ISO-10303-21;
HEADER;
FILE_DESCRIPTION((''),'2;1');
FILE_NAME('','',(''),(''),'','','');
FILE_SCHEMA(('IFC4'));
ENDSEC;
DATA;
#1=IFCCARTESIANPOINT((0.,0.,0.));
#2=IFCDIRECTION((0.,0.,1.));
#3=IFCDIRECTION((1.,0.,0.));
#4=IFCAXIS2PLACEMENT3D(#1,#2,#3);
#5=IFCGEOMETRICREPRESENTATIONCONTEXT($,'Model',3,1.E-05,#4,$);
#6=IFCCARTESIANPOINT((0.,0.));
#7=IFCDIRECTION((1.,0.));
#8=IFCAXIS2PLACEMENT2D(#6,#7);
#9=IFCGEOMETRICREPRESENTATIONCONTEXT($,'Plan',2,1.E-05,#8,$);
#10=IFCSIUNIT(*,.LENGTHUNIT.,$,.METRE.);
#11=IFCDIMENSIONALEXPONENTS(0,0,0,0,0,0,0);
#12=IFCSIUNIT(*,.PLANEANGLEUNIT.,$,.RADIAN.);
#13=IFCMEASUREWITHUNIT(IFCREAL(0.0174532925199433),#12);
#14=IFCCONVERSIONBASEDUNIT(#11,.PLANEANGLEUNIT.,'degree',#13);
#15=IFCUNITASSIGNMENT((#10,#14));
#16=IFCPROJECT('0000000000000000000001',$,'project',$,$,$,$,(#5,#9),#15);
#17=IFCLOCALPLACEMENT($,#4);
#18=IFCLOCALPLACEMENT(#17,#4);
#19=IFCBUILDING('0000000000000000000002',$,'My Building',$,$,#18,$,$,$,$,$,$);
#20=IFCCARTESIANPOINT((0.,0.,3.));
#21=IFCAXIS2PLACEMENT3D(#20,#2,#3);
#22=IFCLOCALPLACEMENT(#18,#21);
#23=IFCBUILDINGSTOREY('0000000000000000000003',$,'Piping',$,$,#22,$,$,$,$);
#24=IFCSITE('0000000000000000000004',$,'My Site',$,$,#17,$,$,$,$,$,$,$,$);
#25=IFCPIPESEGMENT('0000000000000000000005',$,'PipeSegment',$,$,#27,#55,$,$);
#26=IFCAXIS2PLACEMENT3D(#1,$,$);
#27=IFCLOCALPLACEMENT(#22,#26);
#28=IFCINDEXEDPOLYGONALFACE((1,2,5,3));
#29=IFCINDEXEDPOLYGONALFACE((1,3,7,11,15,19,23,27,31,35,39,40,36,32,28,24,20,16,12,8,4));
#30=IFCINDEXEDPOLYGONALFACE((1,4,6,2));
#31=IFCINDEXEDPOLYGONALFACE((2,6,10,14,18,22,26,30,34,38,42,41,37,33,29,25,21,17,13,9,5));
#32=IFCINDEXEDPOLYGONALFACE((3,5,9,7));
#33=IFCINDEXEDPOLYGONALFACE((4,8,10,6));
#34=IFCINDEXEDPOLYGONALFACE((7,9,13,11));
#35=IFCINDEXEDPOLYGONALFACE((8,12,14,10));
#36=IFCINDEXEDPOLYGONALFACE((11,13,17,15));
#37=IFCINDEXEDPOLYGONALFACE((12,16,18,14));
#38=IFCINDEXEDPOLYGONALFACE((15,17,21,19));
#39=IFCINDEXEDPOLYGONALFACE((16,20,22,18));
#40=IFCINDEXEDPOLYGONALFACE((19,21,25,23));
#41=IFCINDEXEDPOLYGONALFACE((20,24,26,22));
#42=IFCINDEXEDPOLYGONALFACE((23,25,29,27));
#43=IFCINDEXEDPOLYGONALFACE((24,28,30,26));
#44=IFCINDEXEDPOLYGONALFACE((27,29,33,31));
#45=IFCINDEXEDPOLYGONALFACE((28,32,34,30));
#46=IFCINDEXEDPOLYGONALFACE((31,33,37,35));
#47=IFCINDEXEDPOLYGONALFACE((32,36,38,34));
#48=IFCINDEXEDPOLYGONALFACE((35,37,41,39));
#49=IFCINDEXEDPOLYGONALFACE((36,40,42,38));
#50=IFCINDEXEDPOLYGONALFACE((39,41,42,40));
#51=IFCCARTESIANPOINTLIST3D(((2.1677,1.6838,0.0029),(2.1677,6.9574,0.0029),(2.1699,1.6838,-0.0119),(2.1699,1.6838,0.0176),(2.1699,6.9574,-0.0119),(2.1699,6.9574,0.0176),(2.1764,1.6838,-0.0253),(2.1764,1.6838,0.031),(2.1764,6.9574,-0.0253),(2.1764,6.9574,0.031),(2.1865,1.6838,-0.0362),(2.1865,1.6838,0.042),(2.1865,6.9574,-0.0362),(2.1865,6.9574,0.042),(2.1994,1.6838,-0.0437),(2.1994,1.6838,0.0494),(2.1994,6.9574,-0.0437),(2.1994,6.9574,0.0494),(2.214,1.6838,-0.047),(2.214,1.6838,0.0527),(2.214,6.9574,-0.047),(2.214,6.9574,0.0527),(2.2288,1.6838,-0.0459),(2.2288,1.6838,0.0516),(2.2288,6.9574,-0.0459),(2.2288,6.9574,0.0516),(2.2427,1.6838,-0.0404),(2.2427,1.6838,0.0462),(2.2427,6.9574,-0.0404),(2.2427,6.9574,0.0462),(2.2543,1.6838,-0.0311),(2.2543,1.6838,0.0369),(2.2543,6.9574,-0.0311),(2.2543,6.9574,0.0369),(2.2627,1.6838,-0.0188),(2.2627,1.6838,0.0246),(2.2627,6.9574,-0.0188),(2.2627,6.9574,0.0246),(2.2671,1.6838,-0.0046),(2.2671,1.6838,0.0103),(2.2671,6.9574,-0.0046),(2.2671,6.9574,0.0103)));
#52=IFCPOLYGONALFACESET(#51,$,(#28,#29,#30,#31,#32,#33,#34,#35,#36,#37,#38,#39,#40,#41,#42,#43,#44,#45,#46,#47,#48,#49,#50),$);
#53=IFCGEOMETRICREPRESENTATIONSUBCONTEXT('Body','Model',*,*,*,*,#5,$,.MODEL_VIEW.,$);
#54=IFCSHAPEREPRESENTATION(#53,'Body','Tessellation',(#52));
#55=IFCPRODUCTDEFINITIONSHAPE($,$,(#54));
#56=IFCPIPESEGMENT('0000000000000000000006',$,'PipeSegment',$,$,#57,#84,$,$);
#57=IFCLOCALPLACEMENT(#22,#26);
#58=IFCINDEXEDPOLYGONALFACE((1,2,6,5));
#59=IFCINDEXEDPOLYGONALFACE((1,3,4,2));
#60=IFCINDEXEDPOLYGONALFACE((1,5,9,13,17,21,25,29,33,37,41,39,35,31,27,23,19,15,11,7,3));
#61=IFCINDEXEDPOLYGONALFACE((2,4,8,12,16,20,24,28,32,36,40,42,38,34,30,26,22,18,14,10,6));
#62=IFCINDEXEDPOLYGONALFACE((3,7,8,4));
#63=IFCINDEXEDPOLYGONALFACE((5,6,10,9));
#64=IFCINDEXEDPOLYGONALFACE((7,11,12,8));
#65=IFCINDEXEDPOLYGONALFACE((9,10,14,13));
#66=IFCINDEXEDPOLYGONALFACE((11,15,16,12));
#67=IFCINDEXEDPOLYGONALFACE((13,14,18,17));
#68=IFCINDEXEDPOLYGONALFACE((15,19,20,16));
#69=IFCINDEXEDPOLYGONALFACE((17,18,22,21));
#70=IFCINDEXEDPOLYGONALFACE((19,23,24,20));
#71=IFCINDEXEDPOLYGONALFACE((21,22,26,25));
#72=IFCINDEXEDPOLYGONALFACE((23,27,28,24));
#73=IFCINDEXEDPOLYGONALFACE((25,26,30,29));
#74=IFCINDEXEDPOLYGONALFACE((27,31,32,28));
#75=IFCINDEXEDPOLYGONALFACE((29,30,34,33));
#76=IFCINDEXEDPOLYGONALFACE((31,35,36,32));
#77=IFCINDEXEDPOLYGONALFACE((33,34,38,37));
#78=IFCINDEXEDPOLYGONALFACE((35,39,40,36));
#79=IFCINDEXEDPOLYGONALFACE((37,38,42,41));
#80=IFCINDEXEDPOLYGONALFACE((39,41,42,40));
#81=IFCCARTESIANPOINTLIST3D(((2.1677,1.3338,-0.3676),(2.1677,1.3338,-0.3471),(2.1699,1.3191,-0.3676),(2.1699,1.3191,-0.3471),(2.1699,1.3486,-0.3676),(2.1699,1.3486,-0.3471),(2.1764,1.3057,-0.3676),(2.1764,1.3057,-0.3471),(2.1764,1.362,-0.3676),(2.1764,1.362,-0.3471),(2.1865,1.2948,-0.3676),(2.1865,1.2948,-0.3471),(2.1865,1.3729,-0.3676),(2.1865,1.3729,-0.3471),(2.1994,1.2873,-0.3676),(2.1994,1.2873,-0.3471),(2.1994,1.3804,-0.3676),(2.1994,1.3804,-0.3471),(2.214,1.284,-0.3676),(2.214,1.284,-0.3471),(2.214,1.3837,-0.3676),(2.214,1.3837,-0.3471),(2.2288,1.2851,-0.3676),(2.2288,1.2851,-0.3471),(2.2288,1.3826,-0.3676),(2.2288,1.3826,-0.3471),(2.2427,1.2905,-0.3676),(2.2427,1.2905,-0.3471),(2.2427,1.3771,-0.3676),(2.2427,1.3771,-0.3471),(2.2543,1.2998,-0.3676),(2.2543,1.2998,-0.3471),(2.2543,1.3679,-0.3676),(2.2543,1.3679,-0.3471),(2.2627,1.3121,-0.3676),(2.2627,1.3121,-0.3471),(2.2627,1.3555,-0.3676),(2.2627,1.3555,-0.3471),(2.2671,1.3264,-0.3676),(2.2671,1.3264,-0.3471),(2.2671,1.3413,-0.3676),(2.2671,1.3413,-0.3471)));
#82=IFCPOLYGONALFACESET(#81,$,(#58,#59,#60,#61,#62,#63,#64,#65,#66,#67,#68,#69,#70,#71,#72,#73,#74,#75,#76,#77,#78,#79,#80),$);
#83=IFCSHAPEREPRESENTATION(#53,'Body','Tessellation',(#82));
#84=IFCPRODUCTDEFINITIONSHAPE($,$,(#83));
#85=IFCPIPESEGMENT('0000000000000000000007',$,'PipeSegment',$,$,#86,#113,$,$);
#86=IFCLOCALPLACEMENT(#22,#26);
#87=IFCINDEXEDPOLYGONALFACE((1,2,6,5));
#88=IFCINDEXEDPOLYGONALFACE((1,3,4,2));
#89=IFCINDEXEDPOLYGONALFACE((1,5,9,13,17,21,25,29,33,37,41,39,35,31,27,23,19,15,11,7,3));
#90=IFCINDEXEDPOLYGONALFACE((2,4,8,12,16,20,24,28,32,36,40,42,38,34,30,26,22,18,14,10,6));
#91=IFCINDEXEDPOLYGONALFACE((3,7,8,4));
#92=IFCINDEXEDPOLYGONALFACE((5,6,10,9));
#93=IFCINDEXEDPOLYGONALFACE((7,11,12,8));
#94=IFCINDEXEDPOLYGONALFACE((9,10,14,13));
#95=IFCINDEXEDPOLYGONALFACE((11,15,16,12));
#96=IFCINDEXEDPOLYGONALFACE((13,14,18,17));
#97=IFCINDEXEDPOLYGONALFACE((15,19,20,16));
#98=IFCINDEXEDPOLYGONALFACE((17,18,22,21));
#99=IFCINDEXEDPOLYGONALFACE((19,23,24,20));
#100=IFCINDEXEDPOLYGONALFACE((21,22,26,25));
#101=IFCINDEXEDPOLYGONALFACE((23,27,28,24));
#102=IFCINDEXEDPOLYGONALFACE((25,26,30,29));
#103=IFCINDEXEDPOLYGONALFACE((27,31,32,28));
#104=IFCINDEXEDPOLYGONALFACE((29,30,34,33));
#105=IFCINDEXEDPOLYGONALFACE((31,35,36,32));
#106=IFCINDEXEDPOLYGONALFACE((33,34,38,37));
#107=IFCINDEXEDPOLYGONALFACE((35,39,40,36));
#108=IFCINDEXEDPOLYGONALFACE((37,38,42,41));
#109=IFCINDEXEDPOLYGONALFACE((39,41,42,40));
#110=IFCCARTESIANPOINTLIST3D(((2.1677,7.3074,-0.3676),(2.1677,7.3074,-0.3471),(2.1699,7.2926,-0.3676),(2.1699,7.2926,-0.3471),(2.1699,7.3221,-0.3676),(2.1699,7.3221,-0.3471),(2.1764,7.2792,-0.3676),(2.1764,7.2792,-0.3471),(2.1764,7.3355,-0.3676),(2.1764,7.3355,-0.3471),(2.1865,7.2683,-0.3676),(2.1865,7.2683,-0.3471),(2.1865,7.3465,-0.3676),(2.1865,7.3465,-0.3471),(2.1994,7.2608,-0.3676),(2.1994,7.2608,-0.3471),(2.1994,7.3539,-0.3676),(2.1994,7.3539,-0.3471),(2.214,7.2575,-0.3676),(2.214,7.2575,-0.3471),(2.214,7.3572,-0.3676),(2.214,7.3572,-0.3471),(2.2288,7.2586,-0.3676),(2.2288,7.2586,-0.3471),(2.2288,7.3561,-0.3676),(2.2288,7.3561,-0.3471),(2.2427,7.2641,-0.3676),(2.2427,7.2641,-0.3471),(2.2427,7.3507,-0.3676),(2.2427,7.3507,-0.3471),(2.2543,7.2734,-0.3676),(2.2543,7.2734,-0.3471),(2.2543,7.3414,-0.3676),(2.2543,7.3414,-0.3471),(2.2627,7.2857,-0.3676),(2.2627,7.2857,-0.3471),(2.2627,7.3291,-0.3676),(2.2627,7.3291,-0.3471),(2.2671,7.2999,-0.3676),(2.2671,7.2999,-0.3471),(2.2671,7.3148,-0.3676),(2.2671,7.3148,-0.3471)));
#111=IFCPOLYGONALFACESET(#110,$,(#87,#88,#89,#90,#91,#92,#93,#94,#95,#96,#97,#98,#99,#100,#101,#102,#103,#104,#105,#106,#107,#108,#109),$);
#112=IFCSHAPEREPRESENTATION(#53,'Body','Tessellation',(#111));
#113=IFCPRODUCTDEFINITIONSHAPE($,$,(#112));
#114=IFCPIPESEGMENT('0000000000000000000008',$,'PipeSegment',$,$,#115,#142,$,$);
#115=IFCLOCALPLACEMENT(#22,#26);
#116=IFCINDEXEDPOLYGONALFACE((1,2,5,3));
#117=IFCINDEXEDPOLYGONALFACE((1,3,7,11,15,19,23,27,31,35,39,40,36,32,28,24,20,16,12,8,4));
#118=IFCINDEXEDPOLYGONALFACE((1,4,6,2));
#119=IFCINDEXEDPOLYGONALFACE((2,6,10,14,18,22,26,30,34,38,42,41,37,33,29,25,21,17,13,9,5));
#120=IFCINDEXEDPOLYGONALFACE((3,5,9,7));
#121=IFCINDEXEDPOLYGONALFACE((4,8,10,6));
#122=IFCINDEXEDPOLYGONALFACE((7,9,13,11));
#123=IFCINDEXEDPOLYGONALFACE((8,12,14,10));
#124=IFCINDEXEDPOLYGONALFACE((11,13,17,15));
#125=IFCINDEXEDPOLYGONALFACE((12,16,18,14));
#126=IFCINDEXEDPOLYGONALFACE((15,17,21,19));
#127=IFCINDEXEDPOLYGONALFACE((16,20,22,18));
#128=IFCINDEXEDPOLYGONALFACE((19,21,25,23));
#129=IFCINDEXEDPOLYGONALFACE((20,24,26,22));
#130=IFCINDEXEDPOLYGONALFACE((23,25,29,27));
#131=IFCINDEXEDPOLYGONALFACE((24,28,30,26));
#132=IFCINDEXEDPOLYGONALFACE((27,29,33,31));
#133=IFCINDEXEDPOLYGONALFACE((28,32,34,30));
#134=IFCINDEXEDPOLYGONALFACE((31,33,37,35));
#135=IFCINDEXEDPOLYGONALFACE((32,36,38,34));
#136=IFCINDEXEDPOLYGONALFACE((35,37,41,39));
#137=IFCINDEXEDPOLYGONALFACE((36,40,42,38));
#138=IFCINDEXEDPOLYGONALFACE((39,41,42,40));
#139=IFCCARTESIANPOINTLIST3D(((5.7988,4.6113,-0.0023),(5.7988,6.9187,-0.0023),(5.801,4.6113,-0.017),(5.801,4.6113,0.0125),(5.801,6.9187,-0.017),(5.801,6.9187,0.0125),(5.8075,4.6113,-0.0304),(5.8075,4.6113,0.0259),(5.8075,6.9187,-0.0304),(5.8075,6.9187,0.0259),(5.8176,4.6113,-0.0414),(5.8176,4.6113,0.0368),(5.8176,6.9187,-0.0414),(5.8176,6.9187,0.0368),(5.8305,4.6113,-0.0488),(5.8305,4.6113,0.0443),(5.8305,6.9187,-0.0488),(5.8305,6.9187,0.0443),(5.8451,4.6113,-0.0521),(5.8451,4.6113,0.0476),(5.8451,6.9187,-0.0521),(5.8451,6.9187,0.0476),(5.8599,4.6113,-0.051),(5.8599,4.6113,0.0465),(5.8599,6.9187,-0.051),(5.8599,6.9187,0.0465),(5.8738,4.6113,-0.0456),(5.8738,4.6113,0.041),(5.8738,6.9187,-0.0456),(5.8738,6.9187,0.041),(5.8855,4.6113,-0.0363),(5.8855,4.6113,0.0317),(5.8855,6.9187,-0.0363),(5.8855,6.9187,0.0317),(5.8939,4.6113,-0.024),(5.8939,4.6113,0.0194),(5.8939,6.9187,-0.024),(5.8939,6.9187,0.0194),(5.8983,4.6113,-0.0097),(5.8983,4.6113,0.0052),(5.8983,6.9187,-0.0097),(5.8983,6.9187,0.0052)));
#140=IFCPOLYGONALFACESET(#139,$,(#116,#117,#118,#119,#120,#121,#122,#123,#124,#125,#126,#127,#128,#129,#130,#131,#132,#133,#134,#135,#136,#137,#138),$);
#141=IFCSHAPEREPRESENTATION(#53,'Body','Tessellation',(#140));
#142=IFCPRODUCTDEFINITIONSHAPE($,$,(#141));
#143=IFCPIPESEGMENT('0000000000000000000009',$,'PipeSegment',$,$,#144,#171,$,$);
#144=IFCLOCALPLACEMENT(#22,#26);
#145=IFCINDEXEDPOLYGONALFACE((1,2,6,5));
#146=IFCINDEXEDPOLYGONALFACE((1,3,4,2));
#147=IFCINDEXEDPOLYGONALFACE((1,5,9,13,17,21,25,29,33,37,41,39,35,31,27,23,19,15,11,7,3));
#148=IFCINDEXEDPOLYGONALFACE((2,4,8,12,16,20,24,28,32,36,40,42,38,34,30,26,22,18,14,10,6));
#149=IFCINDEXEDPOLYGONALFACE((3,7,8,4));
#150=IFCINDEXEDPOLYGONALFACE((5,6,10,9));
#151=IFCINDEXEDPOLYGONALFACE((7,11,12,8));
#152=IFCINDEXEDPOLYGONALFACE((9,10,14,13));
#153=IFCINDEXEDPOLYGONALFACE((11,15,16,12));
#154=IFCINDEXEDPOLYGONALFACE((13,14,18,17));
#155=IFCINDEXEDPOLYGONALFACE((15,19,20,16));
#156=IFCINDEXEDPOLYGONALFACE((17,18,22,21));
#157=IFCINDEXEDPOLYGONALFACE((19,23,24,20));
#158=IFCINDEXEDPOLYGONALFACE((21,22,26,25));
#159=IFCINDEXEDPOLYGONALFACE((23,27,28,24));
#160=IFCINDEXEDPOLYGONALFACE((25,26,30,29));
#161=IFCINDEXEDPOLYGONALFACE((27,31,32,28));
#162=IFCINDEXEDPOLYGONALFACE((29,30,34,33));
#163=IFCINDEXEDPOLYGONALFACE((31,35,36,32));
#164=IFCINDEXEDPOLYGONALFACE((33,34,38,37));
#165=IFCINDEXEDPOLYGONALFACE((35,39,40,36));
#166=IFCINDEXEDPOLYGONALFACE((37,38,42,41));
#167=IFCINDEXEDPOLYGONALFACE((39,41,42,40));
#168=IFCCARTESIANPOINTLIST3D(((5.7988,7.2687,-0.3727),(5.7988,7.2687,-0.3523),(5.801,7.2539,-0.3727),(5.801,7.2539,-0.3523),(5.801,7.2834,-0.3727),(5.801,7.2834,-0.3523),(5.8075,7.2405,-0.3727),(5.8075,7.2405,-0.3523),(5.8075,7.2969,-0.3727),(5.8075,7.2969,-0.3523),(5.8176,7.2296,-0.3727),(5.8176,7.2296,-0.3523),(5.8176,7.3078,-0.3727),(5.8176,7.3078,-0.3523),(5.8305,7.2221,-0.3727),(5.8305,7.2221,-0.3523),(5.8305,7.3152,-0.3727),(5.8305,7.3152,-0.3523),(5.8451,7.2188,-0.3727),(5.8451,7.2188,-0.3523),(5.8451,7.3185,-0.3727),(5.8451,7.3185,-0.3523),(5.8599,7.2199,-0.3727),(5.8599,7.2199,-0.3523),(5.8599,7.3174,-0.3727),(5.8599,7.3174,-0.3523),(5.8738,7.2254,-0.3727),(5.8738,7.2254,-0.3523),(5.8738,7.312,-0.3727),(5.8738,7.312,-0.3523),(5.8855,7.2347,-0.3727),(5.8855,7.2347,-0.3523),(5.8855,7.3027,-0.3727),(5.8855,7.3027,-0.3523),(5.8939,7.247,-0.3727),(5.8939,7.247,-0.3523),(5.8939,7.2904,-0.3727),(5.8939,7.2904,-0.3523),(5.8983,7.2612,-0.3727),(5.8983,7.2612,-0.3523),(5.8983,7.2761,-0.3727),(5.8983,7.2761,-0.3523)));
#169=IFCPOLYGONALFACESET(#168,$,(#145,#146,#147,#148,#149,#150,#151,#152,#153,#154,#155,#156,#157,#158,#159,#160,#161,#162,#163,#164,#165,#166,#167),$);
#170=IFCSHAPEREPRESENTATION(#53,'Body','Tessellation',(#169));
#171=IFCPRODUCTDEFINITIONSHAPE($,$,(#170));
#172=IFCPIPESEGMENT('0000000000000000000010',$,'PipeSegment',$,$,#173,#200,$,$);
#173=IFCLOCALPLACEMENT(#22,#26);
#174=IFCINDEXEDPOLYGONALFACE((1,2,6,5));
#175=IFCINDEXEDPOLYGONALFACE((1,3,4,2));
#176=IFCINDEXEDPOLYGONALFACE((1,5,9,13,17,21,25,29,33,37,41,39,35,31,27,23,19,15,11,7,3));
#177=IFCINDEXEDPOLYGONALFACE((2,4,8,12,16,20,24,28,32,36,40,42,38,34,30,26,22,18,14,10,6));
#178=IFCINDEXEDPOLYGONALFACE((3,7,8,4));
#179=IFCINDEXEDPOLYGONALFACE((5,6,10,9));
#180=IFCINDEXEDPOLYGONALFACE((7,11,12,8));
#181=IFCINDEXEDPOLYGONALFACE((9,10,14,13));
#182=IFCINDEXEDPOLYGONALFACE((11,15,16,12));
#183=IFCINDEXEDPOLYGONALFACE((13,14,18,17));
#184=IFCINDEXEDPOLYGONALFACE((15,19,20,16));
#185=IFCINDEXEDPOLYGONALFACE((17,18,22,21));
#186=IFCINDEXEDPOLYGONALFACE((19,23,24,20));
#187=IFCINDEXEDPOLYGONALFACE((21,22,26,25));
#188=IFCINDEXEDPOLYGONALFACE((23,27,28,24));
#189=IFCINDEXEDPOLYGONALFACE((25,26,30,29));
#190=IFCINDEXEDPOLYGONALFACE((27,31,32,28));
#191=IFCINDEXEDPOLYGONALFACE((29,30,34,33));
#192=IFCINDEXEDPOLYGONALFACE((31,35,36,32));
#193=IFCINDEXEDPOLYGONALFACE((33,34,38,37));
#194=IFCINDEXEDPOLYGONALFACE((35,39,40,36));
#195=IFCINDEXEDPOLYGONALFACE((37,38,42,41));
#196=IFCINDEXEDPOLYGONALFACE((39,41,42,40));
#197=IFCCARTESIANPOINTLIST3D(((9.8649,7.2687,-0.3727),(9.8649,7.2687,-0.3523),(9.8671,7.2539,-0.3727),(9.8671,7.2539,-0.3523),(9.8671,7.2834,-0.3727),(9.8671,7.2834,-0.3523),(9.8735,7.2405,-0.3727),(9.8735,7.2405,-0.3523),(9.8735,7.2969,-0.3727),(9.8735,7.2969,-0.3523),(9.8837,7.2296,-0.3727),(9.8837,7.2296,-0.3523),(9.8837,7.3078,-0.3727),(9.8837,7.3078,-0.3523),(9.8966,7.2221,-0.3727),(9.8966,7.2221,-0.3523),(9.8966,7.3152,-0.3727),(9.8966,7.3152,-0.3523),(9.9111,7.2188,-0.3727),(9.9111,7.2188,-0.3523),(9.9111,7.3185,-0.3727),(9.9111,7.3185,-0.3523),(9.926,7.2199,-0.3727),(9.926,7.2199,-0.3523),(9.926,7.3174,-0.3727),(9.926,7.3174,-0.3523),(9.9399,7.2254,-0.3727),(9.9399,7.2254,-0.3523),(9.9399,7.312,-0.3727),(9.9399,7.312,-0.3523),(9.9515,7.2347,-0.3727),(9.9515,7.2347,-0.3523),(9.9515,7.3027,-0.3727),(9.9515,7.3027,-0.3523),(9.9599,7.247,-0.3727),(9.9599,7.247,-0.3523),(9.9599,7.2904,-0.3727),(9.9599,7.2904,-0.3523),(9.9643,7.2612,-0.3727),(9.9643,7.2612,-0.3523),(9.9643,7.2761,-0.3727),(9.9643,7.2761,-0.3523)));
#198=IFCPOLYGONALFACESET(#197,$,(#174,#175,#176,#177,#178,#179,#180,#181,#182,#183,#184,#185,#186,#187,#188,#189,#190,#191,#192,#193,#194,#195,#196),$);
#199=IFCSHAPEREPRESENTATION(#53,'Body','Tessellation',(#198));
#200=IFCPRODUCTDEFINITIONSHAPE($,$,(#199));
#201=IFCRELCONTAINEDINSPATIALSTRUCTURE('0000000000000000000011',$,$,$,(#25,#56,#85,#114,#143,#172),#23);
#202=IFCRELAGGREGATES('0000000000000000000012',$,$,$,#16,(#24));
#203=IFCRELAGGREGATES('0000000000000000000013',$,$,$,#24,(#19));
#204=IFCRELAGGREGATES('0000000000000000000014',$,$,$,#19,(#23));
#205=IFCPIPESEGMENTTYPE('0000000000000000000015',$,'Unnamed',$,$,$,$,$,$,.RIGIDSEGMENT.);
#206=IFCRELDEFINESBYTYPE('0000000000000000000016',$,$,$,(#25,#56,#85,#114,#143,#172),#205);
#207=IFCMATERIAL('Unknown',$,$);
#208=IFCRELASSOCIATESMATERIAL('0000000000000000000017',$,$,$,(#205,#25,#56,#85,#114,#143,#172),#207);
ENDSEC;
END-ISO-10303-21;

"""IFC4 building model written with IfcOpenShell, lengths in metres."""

from ifc_helpers import new_model, entity, si_unit, converted_unit, frame, origin_with_axes, origin_2d_with_axis, place, context, subcontext, project, spatial, circle, extrude, material, material_profile, profile_set, profile_usage, type_object, element, save


model = new_model("IFC4")

# Units and contexts
model_context = context("Model", 3, precision=1e-05, world=origin_with_axes())
plan_context = context("Plan", 2, precision=1e-05, world=origin_2d_with_axis())
body_context = subcontext(model_context, "Body", "Model", "MODEL_VIEW")
ifc_project = project(units=[si_unit("LENGTHUNIT", "METRE"), converted_unit("PLANEANGLEUNIT", "degree", entity("IfcReal", 0.0174532925199433), si_unit("PLANEANGLEUNIT", "RADIAN"), dimensions=[0, 0, 0, 0, 0, 0, 0])], contexts=[model_context, plan_context])

# Site, building, storey
site_placement = place(None, origin_with_axes())
site = spatial("IfcSite", under=ifc_project, at=site_placement, Name="My Site")
building_placement = place(site_placement, origin_with_axes())
building = spatial("IfcBuilding", under=site, at=building_placement, Name="My Building")
storey_placement = place(building_placement, frame((0.0, 0.0, 3.0), z_axis=(0.0, 0.0, 1.0), x_axis=(1.0, 0.0, 0.0)))
storey = spatial("IfcBuildingStorey", under=building, at=storey_placement, Name="Piping")

# Pipe segments
ifc_material = material(Name="Unknown")
ifc_material_profile_1 = material_profile(ifc_material, circle(Radius=0.05))
ifc_profile_set_1 = profile_set([ifc_material_profile_1])
ifc_profile_usage_1 = profile_usage(ifc_profile_set_1, cardinal=5)
pipe_segment_type = type_object("IfcPipeSegmentType", Name="Unnamed", PredefinedType="RIGIDSEGMENT", material=ifc_profile_set_1)
pipe_segment_1_placement = place(storey_placement, frame((2.2177, 1.6838, 0.0029), z_axis=(0.0, 1.0, 0.0), x_axis=(-1.0, 0.0, 0.0)))
element("IfcPipeSegment", 1, at=pipe_segment_1_placement, inside=storey, type_object=pipe_segment_type, material=ifc_profile_usage_1, Name="PipeSegment", context=body_context, shape_type="SweptSolid", body=[
    extrude(circle(Radius=0.05), origin_with_axes(), (0.0, 0.0, 1.0), 5.2735),
])
ifc_profile_usage_2 = profile_usage(ifc_profile_set_1, cardinal=5)
pipe_segment_2_placement = place(storey_placement, frame((2.2177, 1.3338, -0.3471), z_axis=(0.0, 0.0, -1.0), x_axis=(-1.0, 0.0, 0.0)))
element("IfcPipeSegment", 2, at=pipe_segment_2_placement, inside=storey, type_object=pipe_segment_type, material=ifc_profile_usage_2, Name="PipeSegment", context=body_context, shape_type="SweptSolid", body=[
    extrude(circle(Radius=0.05), origin_with_axes(), (0.0, 0.0, 1.0), 0.0204),
])
ifc_profile_usage_3 = profile_usage(ifc_profile_set_1, cardinal=5)
pipe_segment_3_placement = place(storey_placement, frame((2.2177, 7.3074, -0.3471), z_axis=(0.0, 0.0, -1.0), x_axis=(-1.0, 0.0, 0.0)))
element("IfcPipeSegment", 3, at=pipe_segment_3_placement, inside=storey, type_object=pipe_segment_type, material=ifc_profile_usage_3, Name="PipeSegment", context=body_context, shape_type="SweptSolid", body=[
    extrude(circle(Radius=0.05), origin_with_axes(), (0.0, 0.0, 1.0), 0.0204),
])
ifc_profile_usage_4 = profile_usage(ifc_profile_set_1, cardinal=5)
pipe_segment_4_placement = place(storey_placement, frame((5.8488, 4.6113, -0.0023), z_axis=(0.0, 1.0, 0.0), x_axis=(-1.0, 0.0, 0.0)))
element("IfcPipeSegment", 4, at=pipe_segment_4_placement, inside=storey, type_object=pipe_segment_type, material=ifc_profile_usage_4, Name="PipeSegment", context=body_context, shape_type="SweptSolid", body=[
    extrude(circle(Radius=0.05), origin_with_axes(), (0.0, 0.0, 1.0), 2.3074),
])
ifc_profile_usage_5 = profile_usage(ifc_profile_set_1, cardinal=5)
pipe_segment_5_placement = place(storey_placement, frame((5.8488, 7.2687, -0.3523), z_axis=(0.0, 0.0, -1.0), x_axis=(-1.0, 0.0, 0.0)))
element("IfcPipeSegment", 5, at=pipe_segment_5_placement, inside=storey, type_object=pipe_segment_type, material=ifc_profile_usage_5, Name="PipeSegment", context=body_context, shape_type="SweptSolid", body=[
    extrude(circle(Radius=0.05), origin_with_axes(), (0.0, 0.0, 1.0), 0.0204),
])
ifc_profile_usage_6 = profile_usage(ifc_profile_set_1, cardinal=5)
pipe_segment_6_placement = place(storey_placement, frame((9.9149, 7.2687, -0.3523), z_axis=(0.0, 0.0, -1.0), x_axis=(-1.0, 0.0, 0.0)))
element("IfcPipeSegment", 6, at=pipe_segment_6_placement, inside=storey, type_object=pipe_segment_type, material=ifc_profile_usage_6, Name="PipeSegment", context=body_context, shape_type="SweptSolid", body=[
    extrude(circle(Radius=0.05), origin_with_axes(), (0.0, 0.0, 1.0), 0.0204),
])

save(model, "model.ifc")
